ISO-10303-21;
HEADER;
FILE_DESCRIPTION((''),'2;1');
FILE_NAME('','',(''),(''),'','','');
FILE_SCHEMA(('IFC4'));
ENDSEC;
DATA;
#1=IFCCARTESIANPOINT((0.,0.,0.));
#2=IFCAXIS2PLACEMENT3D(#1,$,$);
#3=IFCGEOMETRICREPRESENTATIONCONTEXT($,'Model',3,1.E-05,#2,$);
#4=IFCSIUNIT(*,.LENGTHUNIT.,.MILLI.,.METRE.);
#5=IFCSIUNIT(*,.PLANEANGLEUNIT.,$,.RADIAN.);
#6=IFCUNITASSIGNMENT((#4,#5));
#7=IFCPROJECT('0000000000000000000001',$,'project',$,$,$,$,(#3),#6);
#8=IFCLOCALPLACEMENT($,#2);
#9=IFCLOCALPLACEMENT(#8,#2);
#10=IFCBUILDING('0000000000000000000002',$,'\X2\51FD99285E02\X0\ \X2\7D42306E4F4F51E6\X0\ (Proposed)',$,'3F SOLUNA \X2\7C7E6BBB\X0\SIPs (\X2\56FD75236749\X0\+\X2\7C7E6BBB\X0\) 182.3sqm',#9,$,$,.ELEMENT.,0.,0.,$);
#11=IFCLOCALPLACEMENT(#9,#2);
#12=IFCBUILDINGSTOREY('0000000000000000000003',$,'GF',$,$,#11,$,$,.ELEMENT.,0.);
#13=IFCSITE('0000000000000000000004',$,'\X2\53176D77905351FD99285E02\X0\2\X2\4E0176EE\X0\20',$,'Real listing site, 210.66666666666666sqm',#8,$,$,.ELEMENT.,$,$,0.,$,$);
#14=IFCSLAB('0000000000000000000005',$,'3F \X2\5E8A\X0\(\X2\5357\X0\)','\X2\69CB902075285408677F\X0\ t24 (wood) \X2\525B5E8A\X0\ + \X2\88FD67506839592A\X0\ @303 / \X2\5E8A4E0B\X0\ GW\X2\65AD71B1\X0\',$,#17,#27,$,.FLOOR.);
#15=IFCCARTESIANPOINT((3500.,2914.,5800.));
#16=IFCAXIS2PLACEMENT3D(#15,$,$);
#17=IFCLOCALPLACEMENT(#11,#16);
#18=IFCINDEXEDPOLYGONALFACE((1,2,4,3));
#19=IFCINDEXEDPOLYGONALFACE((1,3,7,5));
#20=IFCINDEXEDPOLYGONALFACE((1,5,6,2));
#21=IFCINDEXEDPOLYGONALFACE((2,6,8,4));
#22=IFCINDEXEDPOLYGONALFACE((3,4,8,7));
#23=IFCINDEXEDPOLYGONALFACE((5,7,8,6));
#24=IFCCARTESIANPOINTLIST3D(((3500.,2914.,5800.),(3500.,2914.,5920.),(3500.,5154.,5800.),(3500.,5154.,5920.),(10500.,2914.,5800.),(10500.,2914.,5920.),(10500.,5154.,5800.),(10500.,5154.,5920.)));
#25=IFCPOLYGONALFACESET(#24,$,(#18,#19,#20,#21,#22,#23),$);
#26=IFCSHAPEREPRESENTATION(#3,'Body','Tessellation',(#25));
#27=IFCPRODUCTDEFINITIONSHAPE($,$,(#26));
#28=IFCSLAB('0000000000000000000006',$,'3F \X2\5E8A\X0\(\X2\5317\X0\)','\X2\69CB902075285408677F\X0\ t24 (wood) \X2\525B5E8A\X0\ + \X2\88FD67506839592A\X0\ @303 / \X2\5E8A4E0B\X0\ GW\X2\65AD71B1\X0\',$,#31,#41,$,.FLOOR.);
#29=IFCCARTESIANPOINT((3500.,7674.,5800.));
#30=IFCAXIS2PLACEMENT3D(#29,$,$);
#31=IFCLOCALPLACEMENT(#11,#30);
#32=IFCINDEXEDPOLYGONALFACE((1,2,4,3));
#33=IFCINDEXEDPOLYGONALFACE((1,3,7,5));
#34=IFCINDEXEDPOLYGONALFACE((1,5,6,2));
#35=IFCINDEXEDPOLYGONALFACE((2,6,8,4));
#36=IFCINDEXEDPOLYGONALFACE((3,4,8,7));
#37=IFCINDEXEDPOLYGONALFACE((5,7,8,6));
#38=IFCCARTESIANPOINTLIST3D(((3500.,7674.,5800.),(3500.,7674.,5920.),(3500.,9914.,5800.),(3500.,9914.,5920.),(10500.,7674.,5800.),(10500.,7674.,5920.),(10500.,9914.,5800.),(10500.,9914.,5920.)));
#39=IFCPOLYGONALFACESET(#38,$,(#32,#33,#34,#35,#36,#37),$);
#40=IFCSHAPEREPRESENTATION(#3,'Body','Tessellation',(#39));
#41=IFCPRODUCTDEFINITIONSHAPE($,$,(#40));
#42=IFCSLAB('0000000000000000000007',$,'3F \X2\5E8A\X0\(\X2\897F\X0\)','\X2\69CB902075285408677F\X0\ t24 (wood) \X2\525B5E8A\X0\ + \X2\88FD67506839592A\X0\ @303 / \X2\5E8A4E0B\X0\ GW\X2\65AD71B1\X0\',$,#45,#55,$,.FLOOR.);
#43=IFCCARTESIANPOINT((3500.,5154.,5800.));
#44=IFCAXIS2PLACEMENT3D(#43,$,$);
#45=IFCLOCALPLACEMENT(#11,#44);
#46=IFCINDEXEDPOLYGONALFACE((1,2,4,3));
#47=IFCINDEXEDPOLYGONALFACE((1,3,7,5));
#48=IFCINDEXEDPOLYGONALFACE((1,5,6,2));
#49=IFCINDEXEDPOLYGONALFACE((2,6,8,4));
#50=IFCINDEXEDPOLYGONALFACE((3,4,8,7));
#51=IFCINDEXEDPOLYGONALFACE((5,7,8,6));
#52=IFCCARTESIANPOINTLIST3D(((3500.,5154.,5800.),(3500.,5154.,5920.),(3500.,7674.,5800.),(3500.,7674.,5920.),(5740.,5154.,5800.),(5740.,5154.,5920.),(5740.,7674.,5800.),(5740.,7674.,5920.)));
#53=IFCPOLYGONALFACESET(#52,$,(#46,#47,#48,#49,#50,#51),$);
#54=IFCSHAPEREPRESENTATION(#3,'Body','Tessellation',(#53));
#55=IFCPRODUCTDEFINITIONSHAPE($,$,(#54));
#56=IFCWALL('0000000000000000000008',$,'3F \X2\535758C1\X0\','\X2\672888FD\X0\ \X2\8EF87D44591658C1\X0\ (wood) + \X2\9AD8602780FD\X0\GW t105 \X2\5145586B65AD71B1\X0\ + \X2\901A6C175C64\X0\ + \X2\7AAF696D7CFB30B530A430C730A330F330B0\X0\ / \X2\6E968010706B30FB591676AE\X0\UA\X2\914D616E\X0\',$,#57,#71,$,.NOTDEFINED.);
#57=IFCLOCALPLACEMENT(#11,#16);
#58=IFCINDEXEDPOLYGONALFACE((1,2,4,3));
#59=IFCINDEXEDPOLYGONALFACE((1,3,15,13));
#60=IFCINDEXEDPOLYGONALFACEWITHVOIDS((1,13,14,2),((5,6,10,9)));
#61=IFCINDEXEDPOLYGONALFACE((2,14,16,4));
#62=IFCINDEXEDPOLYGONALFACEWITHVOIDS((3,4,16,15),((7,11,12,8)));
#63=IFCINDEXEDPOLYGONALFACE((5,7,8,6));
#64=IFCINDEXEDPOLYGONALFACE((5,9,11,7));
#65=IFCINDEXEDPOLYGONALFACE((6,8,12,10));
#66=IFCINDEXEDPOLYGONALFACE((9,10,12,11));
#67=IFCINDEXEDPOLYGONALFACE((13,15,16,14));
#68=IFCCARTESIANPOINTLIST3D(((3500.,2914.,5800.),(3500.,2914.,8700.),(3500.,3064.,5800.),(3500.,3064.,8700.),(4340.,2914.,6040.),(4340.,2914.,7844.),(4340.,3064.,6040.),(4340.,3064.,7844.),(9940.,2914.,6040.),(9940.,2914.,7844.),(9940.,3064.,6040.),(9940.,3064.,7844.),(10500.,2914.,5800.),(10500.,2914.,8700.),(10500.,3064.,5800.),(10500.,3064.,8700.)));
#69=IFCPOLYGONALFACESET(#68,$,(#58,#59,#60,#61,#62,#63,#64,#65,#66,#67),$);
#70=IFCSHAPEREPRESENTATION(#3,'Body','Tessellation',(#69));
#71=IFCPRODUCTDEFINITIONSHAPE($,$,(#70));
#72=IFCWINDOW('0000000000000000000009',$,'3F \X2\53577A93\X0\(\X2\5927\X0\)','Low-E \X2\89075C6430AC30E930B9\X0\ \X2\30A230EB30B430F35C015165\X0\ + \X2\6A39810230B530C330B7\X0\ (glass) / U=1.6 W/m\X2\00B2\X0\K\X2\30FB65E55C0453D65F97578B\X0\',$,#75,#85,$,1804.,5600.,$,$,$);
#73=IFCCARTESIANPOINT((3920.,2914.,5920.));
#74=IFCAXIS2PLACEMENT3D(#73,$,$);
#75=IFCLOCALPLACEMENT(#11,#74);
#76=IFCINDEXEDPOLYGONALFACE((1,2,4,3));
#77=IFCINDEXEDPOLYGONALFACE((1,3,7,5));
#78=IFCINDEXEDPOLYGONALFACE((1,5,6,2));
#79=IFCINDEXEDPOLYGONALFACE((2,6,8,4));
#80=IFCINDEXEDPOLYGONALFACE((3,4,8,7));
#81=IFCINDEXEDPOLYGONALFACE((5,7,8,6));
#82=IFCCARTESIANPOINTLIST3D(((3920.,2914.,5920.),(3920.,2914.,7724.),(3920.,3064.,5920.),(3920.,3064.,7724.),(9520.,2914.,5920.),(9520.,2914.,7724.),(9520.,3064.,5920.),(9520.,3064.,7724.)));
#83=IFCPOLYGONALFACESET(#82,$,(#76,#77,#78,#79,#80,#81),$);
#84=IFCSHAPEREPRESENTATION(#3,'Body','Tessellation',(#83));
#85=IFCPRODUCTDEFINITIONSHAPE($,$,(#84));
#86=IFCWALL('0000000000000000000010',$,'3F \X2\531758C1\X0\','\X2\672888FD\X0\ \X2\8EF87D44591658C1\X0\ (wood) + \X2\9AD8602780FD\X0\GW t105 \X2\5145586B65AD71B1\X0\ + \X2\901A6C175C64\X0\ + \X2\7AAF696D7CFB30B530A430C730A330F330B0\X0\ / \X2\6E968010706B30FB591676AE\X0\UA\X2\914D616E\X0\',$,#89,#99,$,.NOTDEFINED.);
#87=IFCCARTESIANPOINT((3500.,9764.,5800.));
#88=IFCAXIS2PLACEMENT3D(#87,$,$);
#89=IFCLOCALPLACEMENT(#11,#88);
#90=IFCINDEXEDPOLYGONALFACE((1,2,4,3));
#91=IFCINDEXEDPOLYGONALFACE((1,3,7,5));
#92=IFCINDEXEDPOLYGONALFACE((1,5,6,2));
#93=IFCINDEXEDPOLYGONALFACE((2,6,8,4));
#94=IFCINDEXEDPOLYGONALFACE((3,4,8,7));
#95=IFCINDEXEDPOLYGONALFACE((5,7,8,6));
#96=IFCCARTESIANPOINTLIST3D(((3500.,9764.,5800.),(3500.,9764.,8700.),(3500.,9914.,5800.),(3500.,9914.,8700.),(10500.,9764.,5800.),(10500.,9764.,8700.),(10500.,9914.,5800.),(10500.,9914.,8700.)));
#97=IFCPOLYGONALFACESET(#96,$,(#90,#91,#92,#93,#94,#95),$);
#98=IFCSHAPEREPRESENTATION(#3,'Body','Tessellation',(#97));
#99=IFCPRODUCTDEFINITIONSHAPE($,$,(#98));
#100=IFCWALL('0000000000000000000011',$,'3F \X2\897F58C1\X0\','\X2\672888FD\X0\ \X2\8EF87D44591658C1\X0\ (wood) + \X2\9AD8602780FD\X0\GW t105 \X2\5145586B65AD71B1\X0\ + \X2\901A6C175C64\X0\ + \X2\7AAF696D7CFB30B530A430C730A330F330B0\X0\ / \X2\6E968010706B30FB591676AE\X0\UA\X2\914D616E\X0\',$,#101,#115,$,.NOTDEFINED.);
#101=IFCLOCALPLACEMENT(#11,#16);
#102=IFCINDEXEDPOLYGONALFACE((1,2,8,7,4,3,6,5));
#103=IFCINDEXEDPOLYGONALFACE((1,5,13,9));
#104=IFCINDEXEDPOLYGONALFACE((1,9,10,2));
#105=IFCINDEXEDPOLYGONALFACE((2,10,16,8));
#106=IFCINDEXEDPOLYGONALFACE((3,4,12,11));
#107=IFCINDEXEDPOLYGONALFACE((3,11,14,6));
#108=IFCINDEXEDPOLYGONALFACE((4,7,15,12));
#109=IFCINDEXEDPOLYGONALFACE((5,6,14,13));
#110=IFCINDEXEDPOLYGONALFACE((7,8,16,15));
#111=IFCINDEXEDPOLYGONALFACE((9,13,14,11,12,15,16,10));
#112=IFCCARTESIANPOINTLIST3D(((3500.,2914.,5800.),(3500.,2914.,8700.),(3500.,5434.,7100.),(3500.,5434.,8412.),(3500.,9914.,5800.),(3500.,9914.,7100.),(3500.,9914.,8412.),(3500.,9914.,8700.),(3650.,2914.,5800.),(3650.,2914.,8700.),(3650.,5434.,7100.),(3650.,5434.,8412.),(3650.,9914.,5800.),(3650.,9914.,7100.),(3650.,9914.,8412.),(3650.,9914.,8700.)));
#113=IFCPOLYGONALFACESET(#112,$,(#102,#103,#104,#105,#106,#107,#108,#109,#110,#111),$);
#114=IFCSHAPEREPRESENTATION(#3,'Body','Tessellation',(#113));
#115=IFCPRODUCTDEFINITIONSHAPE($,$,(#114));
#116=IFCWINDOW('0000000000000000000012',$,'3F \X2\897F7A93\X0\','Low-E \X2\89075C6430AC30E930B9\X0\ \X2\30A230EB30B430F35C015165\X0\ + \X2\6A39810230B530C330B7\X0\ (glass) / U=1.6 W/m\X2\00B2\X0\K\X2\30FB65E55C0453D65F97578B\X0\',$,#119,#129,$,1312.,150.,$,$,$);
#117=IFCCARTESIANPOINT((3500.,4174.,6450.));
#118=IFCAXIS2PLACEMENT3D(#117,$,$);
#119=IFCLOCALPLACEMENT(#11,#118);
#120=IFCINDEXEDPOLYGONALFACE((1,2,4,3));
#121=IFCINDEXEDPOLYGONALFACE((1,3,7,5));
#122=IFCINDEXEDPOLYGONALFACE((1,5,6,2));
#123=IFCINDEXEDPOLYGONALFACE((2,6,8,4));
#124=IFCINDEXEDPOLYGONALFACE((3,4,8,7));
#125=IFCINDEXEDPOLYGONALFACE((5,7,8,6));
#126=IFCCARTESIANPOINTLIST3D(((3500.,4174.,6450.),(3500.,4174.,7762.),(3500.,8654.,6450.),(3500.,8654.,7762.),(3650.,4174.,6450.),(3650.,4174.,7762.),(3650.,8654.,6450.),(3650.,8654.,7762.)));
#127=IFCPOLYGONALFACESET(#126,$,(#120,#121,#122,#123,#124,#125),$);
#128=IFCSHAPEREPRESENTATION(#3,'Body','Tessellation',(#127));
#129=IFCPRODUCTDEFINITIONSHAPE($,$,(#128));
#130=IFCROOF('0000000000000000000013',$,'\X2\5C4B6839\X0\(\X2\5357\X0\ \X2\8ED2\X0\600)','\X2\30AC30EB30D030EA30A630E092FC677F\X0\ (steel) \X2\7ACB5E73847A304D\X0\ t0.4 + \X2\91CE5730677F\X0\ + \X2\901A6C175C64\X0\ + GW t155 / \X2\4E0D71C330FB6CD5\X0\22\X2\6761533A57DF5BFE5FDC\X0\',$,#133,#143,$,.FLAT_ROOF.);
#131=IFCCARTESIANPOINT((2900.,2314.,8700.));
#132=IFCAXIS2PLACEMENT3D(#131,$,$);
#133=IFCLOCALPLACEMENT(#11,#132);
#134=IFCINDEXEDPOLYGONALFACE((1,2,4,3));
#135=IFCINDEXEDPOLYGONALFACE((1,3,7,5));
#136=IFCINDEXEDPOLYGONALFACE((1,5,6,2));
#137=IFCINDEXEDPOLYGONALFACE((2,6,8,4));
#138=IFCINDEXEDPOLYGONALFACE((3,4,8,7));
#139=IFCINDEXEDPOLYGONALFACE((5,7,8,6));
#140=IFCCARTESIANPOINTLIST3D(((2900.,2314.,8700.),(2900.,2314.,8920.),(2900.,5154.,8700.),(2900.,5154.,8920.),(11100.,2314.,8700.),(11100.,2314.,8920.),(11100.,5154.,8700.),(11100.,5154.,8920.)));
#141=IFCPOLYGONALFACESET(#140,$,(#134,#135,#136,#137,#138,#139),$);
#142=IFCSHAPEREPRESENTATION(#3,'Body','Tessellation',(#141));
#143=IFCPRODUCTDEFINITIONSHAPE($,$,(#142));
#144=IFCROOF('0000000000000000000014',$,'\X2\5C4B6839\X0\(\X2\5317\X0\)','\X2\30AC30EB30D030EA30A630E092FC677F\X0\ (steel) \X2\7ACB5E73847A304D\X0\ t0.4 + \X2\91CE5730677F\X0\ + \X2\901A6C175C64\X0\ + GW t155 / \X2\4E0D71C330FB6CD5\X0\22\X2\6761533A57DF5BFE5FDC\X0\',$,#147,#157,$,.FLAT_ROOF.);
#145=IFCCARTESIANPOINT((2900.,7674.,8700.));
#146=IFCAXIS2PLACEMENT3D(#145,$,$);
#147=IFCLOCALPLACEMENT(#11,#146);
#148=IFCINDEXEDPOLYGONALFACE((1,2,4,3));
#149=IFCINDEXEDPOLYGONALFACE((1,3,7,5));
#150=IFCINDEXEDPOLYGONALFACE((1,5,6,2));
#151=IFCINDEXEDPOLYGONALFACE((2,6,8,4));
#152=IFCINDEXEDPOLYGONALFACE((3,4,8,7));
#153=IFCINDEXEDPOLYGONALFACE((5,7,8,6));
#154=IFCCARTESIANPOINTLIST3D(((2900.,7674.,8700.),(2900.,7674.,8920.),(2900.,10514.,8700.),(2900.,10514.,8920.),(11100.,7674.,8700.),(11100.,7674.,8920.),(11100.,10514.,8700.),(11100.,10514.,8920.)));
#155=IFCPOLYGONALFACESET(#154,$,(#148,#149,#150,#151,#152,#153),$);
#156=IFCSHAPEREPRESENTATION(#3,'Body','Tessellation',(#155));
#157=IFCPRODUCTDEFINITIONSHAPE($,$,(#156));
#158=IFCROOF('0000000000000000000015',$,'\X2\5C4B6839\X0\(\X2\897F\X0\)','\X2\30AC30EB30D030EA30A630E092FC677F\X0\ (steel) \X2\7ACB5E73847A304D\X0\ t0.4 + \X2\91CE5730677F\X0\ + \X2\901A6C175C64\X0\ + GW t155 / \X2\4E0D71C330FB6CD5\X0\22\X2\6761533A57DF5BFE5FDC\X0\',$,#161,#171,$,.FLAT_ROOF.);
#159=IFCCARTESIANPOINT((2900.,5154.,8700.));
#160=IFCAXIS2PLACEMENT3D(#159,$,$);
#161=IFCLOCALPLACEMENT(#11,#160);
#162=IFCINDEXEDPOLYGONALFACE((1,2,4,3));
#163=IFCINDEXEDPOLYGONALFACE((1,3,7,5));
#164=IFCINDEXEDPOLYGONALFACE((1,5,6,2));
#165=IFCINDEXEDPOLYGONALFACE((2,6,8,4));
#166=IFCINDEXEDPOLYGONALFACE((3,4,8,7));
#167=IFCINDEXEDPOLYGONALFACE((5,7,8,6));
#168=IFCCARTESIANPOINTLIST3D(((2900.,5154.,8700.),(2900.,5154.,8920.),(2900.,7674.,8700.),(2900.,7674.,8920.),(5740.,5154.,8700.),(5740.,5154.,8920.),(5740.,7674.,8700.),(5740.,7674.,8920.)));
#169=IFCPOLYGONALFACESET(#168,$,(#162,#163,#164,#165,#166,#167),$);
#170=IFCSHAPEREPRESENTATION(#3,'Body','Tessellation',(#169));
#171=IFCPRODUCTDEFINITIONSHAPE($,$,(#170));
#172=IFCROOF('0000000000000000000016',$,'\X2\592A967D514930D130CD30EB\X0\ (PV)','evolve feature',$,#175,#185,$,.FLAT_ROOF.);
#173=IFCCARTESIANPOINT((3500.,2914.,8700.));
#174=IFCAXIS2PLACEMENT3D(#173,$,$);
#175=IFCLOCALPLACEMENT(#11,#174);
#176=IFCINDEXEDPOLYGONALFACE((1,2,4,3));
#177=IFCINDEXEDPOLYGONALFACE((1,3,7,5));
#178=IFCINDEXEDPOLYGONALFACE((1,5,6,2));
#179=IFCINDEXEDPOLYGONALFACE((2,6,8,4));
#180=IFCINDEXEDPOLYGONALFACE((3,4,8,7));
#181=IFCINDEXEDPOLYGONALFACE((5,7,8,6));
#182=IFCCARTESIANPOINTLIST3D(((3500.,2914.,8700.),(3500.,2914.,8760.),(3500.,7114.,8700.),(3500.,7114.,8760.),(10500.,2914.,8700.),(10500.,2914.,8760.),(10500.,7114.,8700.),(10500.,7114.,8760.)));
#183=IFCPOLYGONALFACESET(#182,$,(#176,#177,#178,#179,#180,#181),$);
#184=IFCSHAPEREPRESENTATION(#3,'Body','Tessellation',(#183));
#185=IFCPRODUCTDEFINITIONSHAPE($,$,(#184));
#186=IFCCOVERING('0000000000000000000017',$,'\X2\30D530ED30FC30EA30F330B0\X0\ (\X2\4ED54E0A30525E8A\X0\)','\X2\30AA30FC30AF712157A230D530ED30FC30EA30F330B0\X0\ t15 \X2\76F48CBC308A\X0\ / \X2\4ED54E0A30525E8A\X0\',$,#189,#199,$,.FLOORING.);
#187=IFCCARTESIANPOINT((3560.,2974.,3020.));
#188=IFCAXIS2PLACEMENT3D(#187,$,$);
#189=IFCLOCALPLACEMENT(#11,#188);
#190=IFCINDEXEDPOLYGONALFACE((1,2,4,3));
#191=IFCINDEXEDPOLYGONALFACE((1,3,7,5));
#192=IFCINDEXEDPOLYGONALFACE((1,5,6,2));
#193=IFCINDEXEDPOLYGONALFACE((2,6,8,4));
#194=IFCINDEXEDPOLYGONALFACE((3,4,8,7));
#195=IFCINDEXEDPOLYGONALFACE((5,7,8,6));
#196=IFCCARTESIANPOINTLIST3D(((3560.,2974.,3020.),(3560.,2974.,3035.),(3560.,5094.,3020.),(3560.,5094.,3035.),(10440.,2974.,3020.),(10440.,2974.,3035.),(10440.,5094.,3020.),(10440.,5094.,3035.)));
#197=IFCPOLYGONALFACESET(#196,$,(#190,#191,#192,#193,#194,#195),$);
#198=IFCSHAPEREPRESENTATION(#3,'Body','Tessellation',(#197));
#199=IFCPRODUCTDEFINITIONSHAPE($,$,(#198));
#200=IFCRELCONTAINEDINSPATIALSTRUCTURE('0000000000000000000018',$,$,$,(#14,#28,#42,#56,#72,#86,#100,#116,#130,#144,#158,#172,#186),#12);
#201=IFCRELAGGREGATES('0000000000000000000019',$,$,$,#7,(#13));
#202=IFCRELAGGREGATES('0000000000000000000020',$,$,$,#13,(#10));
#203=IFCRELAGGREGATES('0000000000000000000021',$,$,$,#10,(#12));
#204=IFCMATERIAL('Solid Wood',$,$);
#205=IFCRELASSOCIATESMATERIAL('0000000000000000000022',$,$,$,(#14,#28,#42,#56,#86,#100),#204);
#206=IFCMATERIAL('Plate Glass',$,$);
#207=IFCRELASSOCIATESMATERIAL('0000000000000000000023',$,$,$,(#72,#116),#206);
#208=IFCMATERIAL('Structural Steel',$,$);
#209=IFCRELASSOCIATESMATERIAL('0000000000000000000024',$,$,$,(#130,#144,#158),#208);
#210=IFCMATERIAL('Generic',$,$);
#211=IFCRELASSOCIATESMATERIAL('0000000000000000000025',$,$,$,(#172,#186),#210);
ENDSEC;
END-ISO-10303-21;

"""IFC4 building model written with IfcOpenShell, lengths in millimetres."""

from ifc_helpers import new_model, si_unit, frame, frame_2d, origin, place, context, project, spatial, rectangle, extrude, material, element, fill, save


model = new_model("IFC4")

# Units and contexts
model_context = context("Model", 3, precision=1e-05, world=origin())
ifc_project = project(units=[si_unit("LENGTHUNIT", "METRE", prefix="MILLI"), si_unit("PLANEANGLEUNIT", "RADIAN")], contexts=[model_context])

# Site, building, storey
site_placement = place(None, origin())
site = spatial("IfcSite", under=ifc_project, at=site_placement, Name="北海道函館市2丁目20", ObjectType="Real listing site, 210.66666666666666sqm", CompositionType="ELEMENT", RefElevation=0.0)
building_placement = place(site_placement, origin())
building = spatial("IfcBuilding", under=site, at=building_placement, Name="函館市 終の住処 (Proposed)", ObjectType="3F SOLUNA 籾殻SIPs (国産杉+籾殻) 182.3sqm", CompositionType="ELEMENT", ElevationOfRefHeight=0.0, ElevationOfTerrain=0.0)
storey_placement = place(building_placement, origin())
storey = spatial("IfcBuildingStorey", under=building, at=storey_placement, Name="GF", CompositionType="ELEMENT", Elevation=0.0)

# Slabs
ifc_material_1 = material(Name="Solid Wood")
slab_1_placement = place(storey_placement, frame((3500.0, 2914.0, 5800.0)))
element("IfcSlab", 1, at=slab_1_placement, inside=storey, material=ifc_material_1, Name="3F 床(南)", Description="構造用合板 t24 (wood) 剛床 + 製材根太 @303 / 床下 GW断熱", PredefinedType="FLOOR", context=model_context, shape_type="SweptSolid", body=[
    extrude(rectangle(XDim=7000.0, YDim=2240.0, at=frame_2d((3500.0, 1120.0))), frame((3500.0, 2914.0, 5800.0)), (0.0, 0.0, 1.0), 120.0),
])
slab_2_placement = place(storey_placement, frame((3500.0, 7674.0, 5800.0)))
element("IfcSlab", 2, at=slab_2_placement, inside=storey, material=ifc_material_1, Name="3F 床(北)", Description="構造用合板 t24 (wood) 剛床 + 製材根太 @303 / 床下 GW断熱", PredefinedType="FLOOR", context=model_context, shape_type="SweptSolid", body=[
    extrude(rectangle(XDim=7000.0, YDim=2240.0, at=frame_2d((3500.0, 1120.0))), frame((3500.0, 7674.0, 5800.0)), (0.0, 0.0, 1.0), 120.0),
])
slab_3_placement = place(storey_placement, frame((3500.0, 5154.0, 5800.0)))
element("IfcSlab", 3, at=slab_3_placement, inside=storey, material=ifc_material_1, Name="3F 床(西)", Description="構造用合板 t24 (wood) 剛床 + 製材根太 @303 / 床下 GW断熱", PredefinedType="FLOOR", context=model_context, shape_type="SweptSolid", body=[
    extrude(rectangle(XDim=2240.0, YDim=2520.0, at=frame_2d((1120.0, 1260.0))), frame((3500.0, 5154.0, 5800.0)), (0.0, 0.0, 1.0), 120.0),
])

# Wall, opening, window
wall_1_placement = place(storey_placement, frame((3500.0, 2914.0, 5800.0)))
wall_1 = element("IfcWall", 4, at=wall_1_placement, inside=storey, material=ifc_material_1, Name="3F 南壁", Description="木製 軸組外壁 (wood) + 高性能GW t105 充填断熱 + 通気層 + 窯業系サイディング / 準耐火・外皮UA配慮", PredefinedType="NOTDEFINED", context=model_context, shape_type="SweptSolid", body=[
    extrude(rectangle(XDim=7000.0, YDim=150.0, at=frame_2d((3500.0, 75.0))), frame((3500.0, 2914.0, 5800.0)), (0.0, 0.0, 1.0), 2900.0),
])
opening_1_placement = place(storey_placement, frame((3920.0, 2914.0, 5920.0)))
opening_1 = element("IfcOpeningElement", 5, at=opening_1_placement, cuts=wall_1, PredefinedType="NOTDEFINED", context=model_context, shape_type="SweptSolid", body=[
    extrude(rectangle(XDim=5600.0, YDim=150.0, at=frame_2d((2800.0, 75.0))), frame((3920.0, 2914.0, 5920.0)), (0.0, 0.0, 1.0), 1804.0),
])
ifc_material_2 = material(Name="Plate Glass")
window_1_placement = place(storey_placement, frame((3920.0, 2914.0, 5920.0)))
window_1 = element("IfcWindow", 6, at=window_1_placement, inside=storey, material=ifc_material_2, Name="3F 南窓(大)", Description="Low-E 複層ガラス アルゴン封入 + 樹脂サッシ (glass) / U=1.6 W/m²K・日射取得型", OverallHeight=1804.0, OverallWidth=5600.0, context=model_context, shape_type="SweptSolid", body=[
    extrude(rectangle(XDim=5600.0, YDim=150.0, at=frame_2d((2800.0, 75.0))), frame((3920.0, 2914.0, 5920.0)), (0.0, 0.0, 1.0), 1804.0),
])
fill(opening_1, window_1)

# Wall
wall_2_placement = place(storey_placement, frame((3500.0, 9764.0, 5800.0)))
element("IfcWall", 7, at=wall_2_placement, inside=storey, material=ifc_material_1, Name="3F 北壁", Description="木製 軸組外壁 (wood) + 高性能GW t105 充填断熱 + 通気層 + 窯業系サイディング / 準耐火・外皮UA配慮", PredefinedType="NOTDEFINED", context=model_context, shape_type="SweptSolid", body=[
    extrude(rectangle(XDim=7000.0, YDim=150.0, at=frame_2d((3500.0, 75.0))), frame((3500.0, 9764.0, 5800.0)), (0.0, 0.0, 1.0), 2900.0),
])

# Wall, opening, window
wall_3_placement = place(storey_placement, frame((3500.0, 2914.0, 5800.0)))
wall_3 = element("IfcWall", 8, at=wall_3_placement, inside=storey, material=ifc_material_1, Name="3F 西壁", Description="木製 軸組外壁 (wood) + 高性能GW t105 充填断熱 + 通気層 + 窯業系サイディング / 準耐火・外皮UA配慮", PredefinedType="NOTDEFINED", context=model_context, shape_type="SweptSolid", body=[
    extrude(rectangle(XDim=150.0, YDim=7000.0, at=frame_2d((75.0, 3500.0))), frame((3500.0, 2914.0, 5800.0)), (0.0, 0.0, 1.0), 2900.0),
])
opening_2_placement = place(storey_placement, frame((3500.0, 4174.0, 6450.0)))
opening_2 = element("IfcOpeningElement", 9, at=opening_2_placement, cuts=wall_3, PredefinedType="NOTDEFINED", context=model_context, shape_type="SweptSolid", body=[
    extrude(rectangle(XDim=150.0, YDim=4480.0, at=frame_2d((75.0, 2240.0))), frame((3500.0, 4174.0, 6450.0)), (0.0, 0.0, 1.0), 1312.0),
])
window_2_placement = place(storey_placement, frame((3500.0, 4174.0, 6450.0)))
window_2 = element("IfcWindow", 10, at=window_2_placement, inside=storey, material=ifc_material_2, Name="3F 西窓", Description="Low-E 複層ガラス アルゴン封入 + 樹脂サッシ (glass) / U=1.6 W/m²K・日射取得型", OverallHeight=1312.0, OverallWidth=150.0, context=model_context, shape_type="SweptSolid", body=[
    extrude(rectangle(XDim=150.0, YDim=4480.0, at=frame_2d((75.0, 2240.0))), frame((3500.0, 4174.0, 6450.0)), (0.0, 0.0, 1.0), 1312.0),
])
fill(opening_2, window_2)

# Roofs
ifc_material_3 = material(Name="Structural Steel")
roof_1_placement = place(storey_placement, frame((2900.0, 2314.0, 8700.0)))
element("IfcRoof", 11, at=roof_1_placement, inside=storey, material=ifc_material_3, Name="屋根(南 軒600)", Description="ガルバリウム鋼板 (steel) 立平葺き t0.4 + 野地板 + 通気層 + GW t155 / 不燃・法22条区域対応", PredefinedType="FLAT_ROOF", context=model_context, shape_type="SweptSolid", body=[
    extrude(rectangle(XDim=8200.0, YDim=2840.0, at=frame_2d((4100.0, 1420.0))), frame((2900.0, 2314.0, 8700.0)), (0.0, 0.0, 1.0), 220.0),
])
roof_2_placement = place(storey_placement, frame((2900.0, 7674.0, 8700.0)))
element("IfcRoof", 12, at=roof_2_placement, inside=storey, material=ifc_material_3, Name="屋根(北)", Description="ガルバリウム鋼板 (steel) 立平葺き t0.4 + 野地板 + 通気層 + GW t155 / 不燃・法22条区域対応", PredefinedType="FLAT_ROOF", context=model_context, shape_type="SweptSolid", body=[
    extrude(rectangle(XDim=8200.0, YDim=2840.0, at=frame_2d((4100.0, 1420.0))), frame((2900.0, 7674.0, 8700.0)), (0.0, 0.0, 1.0), 220.0),
])
roof_3_placement = place(storey_placement, frame((2900.0, 5154.0, 8700.0)))
element("IfcRoof", 13, at=roof_3_placement, inside=storey, material=ifc_material_3, Name="屋根(西)", Description="ガルバリウム鋼板 (steel) 立平葺き t0.4 + 野地板 + 通気層 + GW t155 / 不燃・法22条区域対応", PredefinedType="FLAT_ROOF", context=model_context, shape_type="SweptSolid", body=[
    extrude(rectangle(XDim=2840.0, YDim=2520.0, at=frame_2d((1420.0, 1260.0))), frame((2900.0, 5154.0, 8700.0)), (0.0, 0.0, 1.0), 220.0),
])
ifc_material_4 = material(Name="Generic")
roof_4_placement = place(storey_placement, frame((3500.0, 2914.0, 8700.0)))
element("IfcRoof", 14, at=roof_4_placement, inside=storey, material=ifc_material_4, Name="太陽光パネル (PV)", Description="evolve feature", PredefinedType="FLAT_ROOF", context=model_context, shape_type="SweptSolid", body=[
    extrude(rectangle(XDim=7000.0, YDim=4200.0, at=frame_2d((3500.0, 2100.0))), frame((3500.0, 2914.0, 8700.0)), (0.0, 0.0, 1.0), 60.0),
])

# Covering
covering_1_placement = place(storey_placement, frame((3560.0, 2974.0, 3020.0)))
element("IfcCovering", 15, at=covering_1_placement, inside=storey, material=ifc_material_4, Name="フローリング (仕上げ床)", Description="オーク無垢フローリング t15 直貼り / 仕上げ床", PredefinedType="FLOORING", context=model_context, shape_type="SweptSolid", body=[
    extrude(rectangle(XDim=6880.0, YDim=2120.0, at=frame_2d((3440.0, 1060.0))), frame((3560.0, 2974.0, 3020.0)), (0.0, 0.0, 1.0), 15.0),
])

save(model, "model.ifc")
